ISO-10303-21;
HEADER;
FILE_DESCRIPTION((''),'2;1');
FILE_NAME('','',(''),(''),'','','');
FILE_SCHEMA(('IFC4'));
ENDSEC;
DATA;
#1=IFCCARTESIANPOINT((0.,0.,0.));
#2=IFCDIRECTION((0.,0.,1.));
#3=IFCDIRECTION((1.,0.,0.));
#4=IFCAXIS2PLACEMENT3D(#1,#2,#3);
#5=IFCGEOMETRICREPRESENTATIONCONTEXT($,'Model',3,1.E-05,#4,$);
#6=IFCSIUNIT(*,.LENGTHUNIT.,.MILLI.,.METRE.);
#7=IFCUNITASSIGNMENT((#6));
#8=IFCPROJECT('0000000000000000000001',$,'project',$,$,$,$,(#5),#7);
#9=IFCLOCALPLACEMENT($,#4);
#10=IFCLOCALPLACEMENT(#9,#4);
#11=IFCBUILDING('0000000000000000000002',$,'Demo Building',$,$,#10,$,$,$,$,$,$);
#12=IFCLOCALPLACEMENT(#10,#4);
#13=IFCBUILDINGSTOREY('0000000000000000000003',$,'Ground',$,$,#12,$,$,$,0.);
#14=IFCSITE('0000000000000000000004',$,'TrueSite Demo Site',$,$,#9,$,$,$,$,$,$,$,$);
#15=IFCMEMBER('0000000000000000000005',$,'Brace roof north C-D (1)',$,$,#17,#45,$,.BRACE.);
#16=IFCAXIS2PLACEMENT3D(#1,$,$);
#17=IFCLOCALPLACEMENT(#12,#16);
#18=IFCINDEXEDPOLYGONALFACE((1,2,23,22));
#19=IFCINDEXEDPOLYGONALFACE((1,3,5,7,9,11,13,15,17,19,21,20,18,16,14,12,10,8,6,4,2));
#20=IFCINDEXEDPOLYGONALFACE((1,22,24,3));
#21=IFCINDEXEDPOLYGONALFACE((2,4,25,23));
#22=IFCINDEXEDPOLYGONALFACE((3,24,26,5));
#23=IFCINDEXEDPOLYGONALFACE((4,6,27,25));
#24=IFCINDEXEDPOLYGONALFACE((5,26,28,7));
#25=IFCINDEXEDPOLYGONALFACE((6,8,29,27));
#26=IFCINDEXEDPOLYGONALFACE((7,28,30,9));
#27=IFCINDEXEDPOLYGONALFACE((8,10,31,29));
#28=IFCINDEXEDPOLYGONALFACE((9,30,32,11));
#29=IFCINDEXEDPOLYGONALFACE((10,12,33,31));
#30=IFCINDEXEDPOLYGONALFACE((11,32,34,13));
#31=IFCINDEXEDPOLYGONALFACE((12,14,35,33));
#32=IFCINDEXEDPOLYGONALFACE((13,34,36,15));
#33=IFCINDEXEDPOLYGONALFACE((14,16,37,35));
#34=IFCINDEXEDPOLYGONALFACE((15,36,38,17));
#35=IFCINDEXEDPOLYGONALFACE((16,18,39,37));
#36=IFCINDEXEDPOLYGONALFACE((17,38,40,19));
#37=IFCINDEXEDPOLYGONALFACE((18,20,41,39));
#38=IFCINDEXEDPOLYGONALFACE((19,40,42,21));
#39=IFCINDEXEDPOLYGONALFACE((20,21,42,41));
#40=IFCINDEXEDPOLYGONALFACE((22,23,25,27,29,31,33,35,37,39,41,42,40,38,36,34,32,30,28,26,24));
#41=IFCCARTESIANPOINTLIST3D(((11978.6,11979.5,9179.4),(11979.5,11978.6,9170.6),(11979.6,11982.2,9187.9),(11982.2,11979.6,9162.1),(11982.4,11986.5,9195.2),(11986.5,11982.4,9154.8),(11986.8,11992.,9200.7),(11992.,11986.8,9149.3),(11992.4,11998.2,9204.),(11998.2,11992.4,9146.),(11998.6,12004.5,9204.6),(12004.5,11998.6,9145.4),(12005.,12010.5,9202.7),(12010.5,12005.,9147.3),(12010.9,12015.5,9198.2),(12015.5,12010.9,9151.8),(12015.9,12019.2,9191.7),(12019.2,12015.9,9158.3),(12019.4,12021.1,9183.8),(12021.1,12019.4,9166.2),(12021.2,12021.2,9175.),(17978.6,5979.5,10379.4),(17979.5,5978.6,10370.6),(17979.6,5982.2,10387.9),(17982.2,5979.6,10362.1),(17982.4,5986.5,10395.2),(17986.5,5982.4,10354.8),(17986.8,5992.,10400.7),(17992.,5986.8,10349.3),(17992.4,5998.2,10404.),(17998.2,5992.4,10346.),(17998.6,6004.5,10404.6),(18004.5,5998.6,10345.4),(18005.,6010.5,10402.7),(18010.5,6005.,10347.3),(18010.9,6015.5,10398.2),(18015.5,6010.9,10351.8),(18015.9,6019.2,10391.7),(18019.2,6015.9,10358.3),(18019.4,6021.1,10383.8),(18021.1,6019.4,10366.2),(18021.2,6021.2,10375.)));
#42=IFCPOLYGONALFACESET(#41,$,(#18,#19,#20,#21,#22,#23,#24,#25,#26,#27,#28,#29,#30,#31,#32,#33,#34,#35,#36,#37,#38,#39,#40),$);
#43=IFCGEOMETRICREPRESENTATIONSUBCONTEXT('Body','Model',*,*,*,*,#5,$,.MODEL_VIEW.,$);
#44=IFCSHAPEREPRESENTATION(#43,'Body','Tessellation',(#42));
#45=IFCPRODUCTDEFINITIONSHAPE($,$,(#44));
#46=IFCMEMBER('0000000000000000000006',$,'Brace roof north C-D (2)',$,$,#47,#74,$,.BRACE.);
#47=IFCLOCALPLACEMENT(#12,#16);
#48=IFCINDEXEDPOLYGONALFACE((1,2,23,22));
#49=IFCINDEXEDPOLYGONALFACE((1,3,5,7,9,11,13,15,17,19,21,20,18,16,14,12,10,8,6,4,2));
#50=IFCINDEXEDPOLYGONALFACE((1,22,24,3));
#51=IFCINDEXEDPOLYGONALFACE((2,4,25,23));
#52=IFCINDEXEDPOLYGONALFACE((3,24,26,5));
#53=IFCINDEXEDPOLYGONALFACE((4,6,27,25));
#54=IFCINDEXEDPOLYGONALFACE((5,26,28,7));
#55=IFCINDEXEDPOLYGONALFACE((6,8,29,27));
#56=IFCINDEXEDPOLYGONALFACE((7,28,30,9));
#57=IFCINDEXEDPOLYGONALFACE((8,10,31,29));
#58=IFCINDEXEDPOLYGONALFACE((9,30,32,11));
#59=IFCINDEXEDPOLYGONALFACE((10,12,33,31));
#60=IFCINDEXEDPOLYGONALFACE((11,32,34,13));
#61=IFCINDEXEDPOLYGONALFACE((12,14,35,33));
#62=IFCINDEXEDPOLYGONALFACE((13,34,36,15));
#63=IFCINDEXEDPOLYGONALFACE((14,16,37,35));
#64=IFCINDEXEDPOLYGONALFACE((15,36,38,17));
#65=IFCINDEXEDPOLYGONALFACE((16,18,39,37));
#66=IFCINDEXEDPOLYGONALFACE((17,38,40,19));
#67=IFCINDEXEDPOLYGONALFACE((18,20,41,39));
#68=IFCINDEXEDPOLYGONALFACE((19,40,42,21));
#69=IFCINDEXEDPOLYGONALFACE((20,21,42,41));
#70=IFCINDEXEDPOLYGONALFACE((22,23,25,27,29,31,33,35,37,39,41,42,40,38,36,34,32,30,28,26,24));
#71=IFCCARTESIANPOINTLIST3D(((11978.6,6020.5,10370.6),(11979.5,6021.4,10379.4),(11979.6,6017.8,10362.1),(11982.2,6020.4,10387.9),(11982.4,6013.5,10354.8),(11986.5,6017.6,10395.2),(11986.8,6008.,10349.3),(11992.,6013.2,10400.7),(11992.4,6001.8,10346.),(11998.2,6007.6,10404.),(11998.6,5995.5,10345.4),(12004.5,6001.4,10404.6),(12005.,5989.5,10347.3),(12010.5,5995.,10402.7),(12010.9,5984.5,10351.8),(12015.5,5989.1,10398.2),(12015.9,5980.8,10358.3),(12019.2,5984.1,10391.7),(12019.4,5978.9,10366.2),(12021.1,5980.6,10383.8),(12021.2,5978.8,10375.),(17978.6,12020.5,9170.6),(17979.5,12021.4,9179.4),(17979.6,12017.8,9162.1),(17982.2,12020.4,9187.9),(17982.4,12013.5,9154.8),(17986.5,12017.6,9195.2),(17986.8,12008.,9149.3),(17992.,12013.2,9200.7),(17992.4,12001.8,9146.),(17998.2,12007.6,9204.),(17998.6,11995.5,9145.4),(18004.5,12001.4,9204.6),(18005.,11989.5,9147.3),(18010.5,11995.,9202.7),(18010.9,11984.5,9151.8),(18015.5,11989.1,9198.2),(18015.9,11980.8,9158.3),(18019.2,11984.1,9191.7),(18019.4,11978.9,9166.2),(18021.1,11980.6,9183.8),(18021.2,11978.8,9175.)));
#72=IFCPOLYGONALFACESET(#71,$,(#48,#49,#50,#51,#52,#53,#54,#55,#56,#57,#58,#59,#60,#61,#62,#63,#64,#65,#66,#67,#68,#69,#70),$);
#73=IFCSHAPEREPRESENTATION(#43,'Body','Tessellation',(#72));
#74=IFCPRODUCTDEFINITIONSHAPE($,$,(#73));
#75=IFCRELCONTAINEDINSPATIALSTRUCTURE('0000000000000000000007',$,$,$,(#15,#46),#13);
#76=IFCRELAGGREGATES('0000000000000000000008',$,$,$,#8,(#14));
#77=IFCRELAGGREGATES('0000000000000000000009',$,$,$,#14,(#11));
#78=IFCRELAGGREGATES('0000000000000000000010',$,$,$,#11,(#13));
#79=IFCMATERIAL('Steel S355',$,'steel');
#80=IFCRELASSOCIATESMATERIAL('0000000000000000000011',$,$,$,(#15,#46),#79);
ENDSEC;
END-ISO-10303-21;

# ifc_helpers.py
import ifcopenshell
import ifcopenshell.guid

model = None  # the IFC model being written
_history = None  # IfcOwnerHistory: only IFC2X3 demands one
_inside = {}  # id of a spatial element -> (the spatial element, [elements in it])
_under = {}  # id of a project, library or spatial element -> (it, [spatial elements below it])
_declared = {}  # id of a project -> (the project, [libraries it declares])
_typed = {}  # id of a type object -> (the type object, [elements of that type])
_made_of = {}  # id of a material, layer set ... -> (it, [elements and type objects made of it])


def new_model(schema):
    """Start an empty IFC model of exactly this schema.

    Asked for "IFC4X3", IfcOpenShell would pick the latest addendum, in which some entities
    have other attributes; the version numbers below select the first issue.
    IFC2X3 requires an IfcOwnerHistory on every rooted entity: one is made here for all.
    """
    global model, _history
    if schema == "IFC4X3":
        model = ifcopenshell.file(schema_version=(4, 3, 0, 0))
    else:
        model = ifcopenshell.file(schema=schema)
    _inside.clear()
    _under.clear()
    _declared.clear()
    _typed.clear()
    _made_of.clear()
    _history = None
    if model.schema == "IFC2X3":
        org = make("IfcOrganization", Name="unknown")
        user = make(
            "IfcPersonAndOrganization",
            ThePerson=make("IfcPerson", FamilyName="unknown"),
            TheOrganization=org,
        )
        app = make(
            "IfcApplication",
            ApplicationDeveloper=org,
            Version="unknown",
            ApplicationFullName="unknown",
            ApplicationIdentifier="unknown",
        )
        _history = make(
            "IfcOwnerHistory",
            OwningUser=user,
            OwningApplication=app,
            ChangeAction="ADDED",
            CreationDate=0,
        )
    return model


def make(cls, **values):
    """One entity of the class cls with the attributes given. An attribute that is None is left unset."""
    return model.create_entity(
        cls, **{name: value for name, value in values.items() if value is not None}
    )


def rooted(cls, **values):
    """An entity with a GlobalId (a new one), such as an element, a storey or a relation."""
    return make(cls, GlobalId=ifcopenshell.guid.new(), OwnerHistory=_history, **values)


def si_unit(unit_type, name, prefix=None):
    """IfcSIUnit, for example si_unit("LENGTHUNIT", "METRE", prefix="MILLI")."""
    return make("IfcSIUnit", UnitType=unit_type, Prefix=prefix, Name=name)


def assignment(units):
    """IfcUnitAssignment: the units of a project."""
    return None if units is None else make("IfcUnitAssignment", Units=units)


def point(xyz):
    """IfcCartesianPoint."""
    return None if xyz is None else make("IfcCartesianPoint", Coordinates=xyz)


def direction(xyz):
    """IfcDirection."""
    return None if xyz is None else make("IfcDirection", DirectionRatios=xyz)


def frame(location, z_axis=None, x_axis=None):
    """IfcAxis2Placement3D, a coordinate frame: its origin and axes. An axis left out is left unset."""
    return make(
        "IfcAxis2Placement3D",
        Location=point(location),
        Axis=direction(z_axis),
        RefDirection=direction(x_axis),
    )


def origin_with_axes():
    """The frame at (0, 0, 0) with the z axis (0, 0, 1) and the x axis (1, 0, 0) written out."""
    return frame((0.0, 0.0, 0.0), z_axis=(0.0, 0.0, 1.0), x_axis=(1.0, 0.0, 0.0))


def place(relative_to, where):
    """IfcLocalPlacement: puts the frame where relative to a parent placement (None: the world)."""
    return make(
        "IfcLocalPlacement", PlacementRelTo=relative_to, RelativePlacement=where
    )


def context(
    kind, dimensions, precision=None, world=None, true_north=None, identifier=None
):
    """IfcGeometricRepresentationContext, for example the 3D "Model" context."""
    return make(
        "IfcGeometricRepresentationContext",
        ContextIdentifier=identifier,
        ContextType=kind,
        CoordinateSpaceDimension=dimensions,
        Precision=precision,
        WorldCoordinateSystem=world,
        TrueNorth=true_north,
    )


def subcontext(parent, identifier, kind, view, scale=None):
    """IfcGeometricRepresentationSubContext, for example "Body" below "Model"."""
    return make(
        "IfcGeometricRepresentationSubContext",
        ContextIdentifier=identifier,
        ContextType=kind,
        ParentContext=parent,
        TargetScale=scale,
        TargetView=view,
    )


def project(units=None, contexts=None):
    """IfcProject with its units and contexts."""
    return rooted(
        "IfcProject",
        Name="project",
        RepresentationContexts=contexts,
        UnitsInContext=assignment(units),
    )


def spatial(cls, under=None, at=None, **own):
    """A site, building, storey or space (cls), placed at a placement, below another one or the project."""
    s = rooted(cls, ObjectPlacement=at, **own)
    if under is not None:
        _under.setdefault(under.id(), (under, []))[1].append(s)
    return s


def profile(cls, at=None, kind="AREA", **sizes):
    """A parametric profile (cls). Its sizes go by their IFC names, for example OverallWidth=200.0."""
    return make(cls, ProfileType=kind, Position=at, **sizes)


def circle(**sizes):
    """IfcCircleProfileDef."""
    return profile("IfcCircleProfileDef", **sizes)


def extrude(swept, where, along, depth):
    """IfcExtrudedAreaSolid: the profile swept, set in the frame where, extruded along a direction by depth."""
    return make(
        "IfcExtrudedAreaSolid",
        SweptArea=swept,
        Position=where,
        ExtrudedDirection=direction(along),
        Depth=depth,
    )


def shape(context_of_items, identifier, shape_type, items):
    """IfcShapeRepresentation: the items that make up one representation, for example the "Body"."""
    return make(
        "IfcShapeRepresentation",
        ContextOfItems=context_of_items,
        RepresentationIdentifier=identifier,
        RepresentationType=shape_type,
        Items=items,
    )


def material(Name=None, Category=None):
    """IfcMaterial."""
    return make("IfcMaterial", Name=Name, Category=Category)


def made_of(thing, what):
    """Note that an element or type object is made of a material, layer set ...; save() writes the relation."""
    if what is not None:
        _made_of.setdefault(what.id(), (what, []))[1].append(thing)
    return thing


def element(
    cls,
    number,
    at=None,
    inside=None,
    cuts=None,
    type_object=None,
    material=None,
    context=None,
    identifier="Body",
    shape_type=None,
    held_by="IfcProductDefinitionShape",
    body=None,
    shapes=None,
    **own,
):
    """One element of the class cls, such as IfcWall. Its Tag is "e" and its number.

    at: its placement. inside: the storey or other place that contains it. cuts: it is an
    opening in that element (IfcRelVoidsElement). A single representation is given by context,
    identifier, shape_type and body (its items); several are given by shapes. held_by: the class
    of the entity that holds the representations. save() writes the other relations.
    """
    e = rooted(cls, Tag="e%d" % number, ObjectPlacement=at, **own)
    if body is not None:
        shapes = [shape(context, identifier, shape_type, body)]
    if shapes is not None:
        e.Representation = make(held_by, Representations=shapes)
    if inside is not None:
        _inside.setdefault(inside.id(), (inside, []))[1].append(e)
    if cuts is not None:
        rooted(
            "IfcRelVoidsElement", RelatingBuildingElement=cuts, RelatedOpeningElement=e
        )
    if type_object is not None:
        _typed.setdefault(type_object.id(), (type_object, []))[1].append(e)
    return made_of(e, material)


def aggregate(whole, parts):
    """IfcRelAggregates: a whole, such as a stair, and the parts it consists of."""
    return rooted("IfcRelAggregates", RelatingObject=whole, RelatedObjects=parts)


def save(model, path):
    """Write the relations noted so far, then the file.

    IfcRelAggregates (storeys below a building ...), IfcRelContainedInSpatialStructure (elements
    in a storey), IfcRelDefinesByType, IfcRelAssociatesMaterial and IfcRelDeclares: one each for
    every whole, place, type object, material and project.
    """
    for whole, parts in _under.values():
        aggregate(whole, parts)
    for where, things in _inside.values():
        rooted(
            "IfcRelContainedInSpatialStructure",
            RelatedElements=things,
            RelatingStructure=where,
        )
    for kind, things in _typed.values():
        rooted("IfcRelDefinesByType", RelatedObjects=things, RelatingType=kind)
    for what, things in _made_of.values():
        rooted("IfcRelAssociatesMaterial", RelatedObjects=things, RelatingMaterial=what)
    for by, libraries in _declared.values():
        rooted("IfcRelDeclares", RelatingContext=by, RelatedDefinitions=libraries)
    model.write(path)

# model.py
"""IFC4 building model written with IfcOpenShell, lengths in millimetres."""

from ifc_helpers import new_model, si_unit, frame, origin_with_axes, place, context, subcontext, project, spatial, circle, extrude, material, element, save


model = new_model("IFC4")

# Units and contexts
model_context = context("Model", 3, precision=1e-05, world=origin_with_axes())
body_context = subcontext(model_context, "Body", "Model", "MODEL_VIEW")
ifc_project = project(units=[si_unit("LENGTHUNIT", "METRE", prefix="MILLI")], contexts=[model_context])

# Site, building, storey
site_placement = place(None, origin_with_axes())
site = spatial("IfcSite", under=ifc_project, at=site_placement, Name="TrueSite Demo Site")
building_placement = place(site_placement, origin_with_axes())
building = spatial("IfcBuilding", under=site, at=building_placement, Name="Demo Building")
storey_placement = place(building_placement, origin_with_axes())
storey = spatial("IfcBuildingStorey", under=building, at=storey_placement, Name="Ground", Elevation=0.0)

# Shared definitions
ifc_material_1 = material(Name="Steel S355", Category="steel")

# Members
for number, where, z_axis, x_axis, name in (
    (1, (12000.0, 12000.0, 9175.0), (0.70014, -0.70014, 0.140028), (0.707107, 0.707107, 0.0), "Brace roof north C-D (1)"),
    (2, (18000.0, 12000.0, 9175.0), (-0.70014, -0.70014, 0.140028), (0.707107, -0.707107, 0.0), "Brace roof north C-D (2)"),
):
    element("IfcMember", number, at=place(storey_placement, frame(where, z_axis=z_axis, x_axis=x_axis)), inside=storey, material=ifc_material_1, Name=name, PredefinedType="BRACE", context=body_context, shape_type="SweptSolid", body=[
        extrude(circle(Radius=30.0), origin_with_axes(), (0.0, 0.0, 1.0), 8569.7),
    ])

save(model, "model.ifc")
